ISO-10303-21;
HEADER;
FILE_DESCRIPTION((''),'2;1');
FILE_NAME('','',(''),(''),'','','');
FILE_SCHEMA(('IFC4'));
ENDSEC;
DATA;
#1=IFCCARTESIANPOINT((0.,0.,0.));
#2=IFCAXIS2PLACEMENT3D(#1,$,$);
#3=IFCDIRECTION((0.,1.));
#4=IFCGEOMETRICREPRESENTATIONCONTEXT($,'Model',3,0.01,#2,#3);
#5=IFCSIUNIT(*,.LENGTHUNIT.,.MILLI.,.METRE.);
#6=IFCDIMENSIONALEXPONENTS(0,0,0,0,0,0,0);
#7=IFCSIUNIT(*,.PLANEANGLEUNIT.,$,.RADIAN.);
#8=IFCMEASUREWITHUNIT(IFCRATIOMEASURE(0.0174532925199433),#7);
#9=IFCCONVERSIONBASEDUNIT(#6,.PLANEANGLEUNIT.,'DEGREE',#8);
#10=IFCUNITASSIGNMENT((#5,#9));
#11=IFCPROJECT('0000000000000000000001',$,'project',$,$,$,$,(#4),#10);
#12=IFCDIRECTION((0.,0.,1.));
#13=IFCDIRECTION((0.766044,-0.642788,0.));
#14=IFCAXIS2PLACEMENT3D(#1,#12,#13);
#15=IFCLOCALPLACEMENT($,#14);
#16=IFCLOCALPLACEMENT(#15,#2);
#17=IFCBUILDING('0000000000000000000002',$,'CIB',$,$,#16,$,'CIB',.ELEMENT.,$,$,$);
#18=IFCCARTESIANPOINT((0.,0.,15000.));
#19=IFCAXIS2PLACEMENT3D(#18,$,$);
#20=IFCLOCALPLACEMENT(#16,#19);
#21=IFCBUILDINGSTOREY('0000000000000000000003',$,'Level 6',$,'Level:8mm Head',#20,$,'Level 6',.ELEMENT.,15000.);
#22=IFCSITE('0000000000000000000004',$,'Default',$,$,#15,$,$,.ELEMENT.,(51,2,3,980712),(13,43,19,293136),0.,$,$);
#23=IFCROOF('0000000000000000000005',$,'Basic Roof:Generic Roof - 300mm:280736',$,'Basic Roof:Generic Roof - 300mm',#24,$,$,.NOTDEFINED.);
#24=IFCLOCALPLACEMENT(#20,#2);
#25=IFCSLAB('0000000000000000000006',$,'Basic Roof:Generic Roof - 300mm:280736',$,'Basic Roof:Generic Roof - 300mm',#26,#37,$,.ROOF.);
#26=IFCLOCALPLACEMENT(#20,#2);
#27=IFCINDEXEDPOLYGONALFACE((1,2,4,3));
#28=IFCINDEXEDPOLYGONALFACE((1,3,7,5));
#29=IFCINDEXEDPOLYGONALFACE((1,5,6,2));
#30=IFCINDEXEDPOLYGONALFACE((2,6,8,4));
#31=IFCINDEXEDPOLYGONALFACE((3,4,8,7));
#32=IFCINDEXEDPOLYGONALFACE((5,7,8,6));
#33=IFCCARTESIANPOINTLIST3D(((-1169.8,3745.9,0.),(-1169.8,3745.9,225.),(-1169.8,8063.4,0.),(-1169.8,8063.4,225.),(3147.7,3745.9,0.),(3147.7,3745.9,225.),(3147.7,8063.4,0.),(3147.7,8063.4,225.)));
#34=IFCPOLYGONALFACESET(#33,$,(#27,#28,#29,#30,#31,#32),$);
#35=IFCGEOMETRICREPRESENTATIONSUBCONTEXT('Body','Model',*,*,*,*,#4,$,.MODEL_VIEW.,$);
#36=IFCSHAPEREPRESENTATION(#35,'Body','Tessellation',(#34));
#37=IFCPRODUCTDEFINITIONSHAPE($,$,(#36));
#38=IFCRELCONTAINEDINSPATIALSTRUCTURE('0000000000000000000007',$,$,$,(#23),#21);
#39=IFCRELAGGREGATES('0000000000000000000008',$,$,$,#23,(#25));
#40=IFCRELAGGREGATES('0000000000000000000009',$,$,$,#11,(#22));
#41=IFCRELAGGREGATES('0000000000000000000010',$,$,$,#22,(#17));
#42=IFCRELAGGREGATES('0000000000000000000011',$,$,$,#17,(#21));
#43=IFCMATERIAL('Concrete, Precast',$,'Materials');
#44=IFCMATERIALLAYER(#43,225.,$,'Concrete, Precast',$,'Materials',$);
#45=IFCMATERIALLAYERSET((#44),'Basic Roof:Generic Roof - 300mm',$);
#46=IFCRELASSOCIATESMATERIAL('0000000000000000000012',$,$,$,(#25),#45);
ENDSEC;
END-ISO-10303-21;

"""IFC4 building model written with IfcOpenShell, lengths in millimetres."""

from ifc_helpers import new_model, entity, si_unit, converted_unit, direction, frame, origin, place, context, subcontext, project, spatial, indexed_curve, outline, extrude, material, layer, layer_set, element, aggregate, save


model = new_model("IFC4")

# Units and contexts
model_context = context("Model", 3, precision=0.01, world=origin(), true_north=direction((0.0, 1.0)))
body_context = subcontext(model_context, "Body", "Model", "MODEL_VIEW")
ifc_project = project(units=[si_unit("LENGTHUNIT", "METRE", prefix="MILLI"), converted_unit("PLANEANGLEUNIT", "DEGREE", entity("IfcRatioMeasure", 0.0174532925199433), si_unit("PLANEANGLEUNIT", "RADIAN"), dimensions=[0, 0, 0, 0, 0, 0, 0])], contexts=[model_context])

# Site, building, storey
site_placement = place(None, frame((0.0, 0.0, 0.0), z_axis=(0.0, 0.0, 1.0), x_axis=(0.766044, -0.642788, 0.0)))
site = spatial("IfcSite", under=ifc_project, at=site_placement, Name="Default", CompositionType="ELEMENT", RefLatitude=(51, 2, 3, 980712), RefLongitude=(13, 43, 19, 293136), RefElevation=0.0)
building_placement = place(site_placement, origin())
building = spatial("IfcBuilding", under=site, at=building_placement, Name="CIB", LongName="CIB", CompositionType="ELEMENT")
storey_placement = place(building_placement, frame((0.0, 0.0, 15000.0)))
storey = spatial("IfcBuildingStorey", under=building, at=storey_placement, Name="Level 6", ObjectType="Level:8mm Head", LongName="Level 6", CompositionType="ELEMENT", Elevation=15000.0)

# Roof, slab
roof_placement = place(storey_placement, frame((-1169.8, 3745.9, 0.0)))
roof = element("IfcRoof", 1, at=roof_placement, inside=storey, Name="Basic Roof:Generic Roof - 300mm:280736", ObjectType="Basic Roof:Generic Roof - 300mm", PredefinedType="NOTDEFINED")
ifc_material = material(Name="Concrete, Precast", Category="Materials")
ifc_layer = layer(ifc_material, 225.0, Name="Concrete, Precast", Category="Materials")
ifc_layer_set = layer_set([ifc_layer], Name="Basic Roof:Generic Roof - 300mm")
slab_placement = place(roof_placement, origin())
slab = element("IfcSlab", 2, at=slab_placement, material=ifc_layer_set, Name="Basic Roof:Generic Roof - 300mm:280736", ObjectType="Basic Roof:Generic Roof - 300mm", PredefinedType="ROOF", context=body_context, shape_type="SweptSolid", body=[
    extrude(outline(indexed_curve([(-2158.8, -2158.7), (2158.7, -2158.8), (2158.8, 2158.7), (-2158.7, 2158.8), (-2158.8, -2158.7)], self_intersect=False)), frame((2158.8, 2158.8, 0.0)), (0.0, 0.0, 1.0), 225.0),
])
aggregate(roof, [slab])

save(model, "model.ifc")
